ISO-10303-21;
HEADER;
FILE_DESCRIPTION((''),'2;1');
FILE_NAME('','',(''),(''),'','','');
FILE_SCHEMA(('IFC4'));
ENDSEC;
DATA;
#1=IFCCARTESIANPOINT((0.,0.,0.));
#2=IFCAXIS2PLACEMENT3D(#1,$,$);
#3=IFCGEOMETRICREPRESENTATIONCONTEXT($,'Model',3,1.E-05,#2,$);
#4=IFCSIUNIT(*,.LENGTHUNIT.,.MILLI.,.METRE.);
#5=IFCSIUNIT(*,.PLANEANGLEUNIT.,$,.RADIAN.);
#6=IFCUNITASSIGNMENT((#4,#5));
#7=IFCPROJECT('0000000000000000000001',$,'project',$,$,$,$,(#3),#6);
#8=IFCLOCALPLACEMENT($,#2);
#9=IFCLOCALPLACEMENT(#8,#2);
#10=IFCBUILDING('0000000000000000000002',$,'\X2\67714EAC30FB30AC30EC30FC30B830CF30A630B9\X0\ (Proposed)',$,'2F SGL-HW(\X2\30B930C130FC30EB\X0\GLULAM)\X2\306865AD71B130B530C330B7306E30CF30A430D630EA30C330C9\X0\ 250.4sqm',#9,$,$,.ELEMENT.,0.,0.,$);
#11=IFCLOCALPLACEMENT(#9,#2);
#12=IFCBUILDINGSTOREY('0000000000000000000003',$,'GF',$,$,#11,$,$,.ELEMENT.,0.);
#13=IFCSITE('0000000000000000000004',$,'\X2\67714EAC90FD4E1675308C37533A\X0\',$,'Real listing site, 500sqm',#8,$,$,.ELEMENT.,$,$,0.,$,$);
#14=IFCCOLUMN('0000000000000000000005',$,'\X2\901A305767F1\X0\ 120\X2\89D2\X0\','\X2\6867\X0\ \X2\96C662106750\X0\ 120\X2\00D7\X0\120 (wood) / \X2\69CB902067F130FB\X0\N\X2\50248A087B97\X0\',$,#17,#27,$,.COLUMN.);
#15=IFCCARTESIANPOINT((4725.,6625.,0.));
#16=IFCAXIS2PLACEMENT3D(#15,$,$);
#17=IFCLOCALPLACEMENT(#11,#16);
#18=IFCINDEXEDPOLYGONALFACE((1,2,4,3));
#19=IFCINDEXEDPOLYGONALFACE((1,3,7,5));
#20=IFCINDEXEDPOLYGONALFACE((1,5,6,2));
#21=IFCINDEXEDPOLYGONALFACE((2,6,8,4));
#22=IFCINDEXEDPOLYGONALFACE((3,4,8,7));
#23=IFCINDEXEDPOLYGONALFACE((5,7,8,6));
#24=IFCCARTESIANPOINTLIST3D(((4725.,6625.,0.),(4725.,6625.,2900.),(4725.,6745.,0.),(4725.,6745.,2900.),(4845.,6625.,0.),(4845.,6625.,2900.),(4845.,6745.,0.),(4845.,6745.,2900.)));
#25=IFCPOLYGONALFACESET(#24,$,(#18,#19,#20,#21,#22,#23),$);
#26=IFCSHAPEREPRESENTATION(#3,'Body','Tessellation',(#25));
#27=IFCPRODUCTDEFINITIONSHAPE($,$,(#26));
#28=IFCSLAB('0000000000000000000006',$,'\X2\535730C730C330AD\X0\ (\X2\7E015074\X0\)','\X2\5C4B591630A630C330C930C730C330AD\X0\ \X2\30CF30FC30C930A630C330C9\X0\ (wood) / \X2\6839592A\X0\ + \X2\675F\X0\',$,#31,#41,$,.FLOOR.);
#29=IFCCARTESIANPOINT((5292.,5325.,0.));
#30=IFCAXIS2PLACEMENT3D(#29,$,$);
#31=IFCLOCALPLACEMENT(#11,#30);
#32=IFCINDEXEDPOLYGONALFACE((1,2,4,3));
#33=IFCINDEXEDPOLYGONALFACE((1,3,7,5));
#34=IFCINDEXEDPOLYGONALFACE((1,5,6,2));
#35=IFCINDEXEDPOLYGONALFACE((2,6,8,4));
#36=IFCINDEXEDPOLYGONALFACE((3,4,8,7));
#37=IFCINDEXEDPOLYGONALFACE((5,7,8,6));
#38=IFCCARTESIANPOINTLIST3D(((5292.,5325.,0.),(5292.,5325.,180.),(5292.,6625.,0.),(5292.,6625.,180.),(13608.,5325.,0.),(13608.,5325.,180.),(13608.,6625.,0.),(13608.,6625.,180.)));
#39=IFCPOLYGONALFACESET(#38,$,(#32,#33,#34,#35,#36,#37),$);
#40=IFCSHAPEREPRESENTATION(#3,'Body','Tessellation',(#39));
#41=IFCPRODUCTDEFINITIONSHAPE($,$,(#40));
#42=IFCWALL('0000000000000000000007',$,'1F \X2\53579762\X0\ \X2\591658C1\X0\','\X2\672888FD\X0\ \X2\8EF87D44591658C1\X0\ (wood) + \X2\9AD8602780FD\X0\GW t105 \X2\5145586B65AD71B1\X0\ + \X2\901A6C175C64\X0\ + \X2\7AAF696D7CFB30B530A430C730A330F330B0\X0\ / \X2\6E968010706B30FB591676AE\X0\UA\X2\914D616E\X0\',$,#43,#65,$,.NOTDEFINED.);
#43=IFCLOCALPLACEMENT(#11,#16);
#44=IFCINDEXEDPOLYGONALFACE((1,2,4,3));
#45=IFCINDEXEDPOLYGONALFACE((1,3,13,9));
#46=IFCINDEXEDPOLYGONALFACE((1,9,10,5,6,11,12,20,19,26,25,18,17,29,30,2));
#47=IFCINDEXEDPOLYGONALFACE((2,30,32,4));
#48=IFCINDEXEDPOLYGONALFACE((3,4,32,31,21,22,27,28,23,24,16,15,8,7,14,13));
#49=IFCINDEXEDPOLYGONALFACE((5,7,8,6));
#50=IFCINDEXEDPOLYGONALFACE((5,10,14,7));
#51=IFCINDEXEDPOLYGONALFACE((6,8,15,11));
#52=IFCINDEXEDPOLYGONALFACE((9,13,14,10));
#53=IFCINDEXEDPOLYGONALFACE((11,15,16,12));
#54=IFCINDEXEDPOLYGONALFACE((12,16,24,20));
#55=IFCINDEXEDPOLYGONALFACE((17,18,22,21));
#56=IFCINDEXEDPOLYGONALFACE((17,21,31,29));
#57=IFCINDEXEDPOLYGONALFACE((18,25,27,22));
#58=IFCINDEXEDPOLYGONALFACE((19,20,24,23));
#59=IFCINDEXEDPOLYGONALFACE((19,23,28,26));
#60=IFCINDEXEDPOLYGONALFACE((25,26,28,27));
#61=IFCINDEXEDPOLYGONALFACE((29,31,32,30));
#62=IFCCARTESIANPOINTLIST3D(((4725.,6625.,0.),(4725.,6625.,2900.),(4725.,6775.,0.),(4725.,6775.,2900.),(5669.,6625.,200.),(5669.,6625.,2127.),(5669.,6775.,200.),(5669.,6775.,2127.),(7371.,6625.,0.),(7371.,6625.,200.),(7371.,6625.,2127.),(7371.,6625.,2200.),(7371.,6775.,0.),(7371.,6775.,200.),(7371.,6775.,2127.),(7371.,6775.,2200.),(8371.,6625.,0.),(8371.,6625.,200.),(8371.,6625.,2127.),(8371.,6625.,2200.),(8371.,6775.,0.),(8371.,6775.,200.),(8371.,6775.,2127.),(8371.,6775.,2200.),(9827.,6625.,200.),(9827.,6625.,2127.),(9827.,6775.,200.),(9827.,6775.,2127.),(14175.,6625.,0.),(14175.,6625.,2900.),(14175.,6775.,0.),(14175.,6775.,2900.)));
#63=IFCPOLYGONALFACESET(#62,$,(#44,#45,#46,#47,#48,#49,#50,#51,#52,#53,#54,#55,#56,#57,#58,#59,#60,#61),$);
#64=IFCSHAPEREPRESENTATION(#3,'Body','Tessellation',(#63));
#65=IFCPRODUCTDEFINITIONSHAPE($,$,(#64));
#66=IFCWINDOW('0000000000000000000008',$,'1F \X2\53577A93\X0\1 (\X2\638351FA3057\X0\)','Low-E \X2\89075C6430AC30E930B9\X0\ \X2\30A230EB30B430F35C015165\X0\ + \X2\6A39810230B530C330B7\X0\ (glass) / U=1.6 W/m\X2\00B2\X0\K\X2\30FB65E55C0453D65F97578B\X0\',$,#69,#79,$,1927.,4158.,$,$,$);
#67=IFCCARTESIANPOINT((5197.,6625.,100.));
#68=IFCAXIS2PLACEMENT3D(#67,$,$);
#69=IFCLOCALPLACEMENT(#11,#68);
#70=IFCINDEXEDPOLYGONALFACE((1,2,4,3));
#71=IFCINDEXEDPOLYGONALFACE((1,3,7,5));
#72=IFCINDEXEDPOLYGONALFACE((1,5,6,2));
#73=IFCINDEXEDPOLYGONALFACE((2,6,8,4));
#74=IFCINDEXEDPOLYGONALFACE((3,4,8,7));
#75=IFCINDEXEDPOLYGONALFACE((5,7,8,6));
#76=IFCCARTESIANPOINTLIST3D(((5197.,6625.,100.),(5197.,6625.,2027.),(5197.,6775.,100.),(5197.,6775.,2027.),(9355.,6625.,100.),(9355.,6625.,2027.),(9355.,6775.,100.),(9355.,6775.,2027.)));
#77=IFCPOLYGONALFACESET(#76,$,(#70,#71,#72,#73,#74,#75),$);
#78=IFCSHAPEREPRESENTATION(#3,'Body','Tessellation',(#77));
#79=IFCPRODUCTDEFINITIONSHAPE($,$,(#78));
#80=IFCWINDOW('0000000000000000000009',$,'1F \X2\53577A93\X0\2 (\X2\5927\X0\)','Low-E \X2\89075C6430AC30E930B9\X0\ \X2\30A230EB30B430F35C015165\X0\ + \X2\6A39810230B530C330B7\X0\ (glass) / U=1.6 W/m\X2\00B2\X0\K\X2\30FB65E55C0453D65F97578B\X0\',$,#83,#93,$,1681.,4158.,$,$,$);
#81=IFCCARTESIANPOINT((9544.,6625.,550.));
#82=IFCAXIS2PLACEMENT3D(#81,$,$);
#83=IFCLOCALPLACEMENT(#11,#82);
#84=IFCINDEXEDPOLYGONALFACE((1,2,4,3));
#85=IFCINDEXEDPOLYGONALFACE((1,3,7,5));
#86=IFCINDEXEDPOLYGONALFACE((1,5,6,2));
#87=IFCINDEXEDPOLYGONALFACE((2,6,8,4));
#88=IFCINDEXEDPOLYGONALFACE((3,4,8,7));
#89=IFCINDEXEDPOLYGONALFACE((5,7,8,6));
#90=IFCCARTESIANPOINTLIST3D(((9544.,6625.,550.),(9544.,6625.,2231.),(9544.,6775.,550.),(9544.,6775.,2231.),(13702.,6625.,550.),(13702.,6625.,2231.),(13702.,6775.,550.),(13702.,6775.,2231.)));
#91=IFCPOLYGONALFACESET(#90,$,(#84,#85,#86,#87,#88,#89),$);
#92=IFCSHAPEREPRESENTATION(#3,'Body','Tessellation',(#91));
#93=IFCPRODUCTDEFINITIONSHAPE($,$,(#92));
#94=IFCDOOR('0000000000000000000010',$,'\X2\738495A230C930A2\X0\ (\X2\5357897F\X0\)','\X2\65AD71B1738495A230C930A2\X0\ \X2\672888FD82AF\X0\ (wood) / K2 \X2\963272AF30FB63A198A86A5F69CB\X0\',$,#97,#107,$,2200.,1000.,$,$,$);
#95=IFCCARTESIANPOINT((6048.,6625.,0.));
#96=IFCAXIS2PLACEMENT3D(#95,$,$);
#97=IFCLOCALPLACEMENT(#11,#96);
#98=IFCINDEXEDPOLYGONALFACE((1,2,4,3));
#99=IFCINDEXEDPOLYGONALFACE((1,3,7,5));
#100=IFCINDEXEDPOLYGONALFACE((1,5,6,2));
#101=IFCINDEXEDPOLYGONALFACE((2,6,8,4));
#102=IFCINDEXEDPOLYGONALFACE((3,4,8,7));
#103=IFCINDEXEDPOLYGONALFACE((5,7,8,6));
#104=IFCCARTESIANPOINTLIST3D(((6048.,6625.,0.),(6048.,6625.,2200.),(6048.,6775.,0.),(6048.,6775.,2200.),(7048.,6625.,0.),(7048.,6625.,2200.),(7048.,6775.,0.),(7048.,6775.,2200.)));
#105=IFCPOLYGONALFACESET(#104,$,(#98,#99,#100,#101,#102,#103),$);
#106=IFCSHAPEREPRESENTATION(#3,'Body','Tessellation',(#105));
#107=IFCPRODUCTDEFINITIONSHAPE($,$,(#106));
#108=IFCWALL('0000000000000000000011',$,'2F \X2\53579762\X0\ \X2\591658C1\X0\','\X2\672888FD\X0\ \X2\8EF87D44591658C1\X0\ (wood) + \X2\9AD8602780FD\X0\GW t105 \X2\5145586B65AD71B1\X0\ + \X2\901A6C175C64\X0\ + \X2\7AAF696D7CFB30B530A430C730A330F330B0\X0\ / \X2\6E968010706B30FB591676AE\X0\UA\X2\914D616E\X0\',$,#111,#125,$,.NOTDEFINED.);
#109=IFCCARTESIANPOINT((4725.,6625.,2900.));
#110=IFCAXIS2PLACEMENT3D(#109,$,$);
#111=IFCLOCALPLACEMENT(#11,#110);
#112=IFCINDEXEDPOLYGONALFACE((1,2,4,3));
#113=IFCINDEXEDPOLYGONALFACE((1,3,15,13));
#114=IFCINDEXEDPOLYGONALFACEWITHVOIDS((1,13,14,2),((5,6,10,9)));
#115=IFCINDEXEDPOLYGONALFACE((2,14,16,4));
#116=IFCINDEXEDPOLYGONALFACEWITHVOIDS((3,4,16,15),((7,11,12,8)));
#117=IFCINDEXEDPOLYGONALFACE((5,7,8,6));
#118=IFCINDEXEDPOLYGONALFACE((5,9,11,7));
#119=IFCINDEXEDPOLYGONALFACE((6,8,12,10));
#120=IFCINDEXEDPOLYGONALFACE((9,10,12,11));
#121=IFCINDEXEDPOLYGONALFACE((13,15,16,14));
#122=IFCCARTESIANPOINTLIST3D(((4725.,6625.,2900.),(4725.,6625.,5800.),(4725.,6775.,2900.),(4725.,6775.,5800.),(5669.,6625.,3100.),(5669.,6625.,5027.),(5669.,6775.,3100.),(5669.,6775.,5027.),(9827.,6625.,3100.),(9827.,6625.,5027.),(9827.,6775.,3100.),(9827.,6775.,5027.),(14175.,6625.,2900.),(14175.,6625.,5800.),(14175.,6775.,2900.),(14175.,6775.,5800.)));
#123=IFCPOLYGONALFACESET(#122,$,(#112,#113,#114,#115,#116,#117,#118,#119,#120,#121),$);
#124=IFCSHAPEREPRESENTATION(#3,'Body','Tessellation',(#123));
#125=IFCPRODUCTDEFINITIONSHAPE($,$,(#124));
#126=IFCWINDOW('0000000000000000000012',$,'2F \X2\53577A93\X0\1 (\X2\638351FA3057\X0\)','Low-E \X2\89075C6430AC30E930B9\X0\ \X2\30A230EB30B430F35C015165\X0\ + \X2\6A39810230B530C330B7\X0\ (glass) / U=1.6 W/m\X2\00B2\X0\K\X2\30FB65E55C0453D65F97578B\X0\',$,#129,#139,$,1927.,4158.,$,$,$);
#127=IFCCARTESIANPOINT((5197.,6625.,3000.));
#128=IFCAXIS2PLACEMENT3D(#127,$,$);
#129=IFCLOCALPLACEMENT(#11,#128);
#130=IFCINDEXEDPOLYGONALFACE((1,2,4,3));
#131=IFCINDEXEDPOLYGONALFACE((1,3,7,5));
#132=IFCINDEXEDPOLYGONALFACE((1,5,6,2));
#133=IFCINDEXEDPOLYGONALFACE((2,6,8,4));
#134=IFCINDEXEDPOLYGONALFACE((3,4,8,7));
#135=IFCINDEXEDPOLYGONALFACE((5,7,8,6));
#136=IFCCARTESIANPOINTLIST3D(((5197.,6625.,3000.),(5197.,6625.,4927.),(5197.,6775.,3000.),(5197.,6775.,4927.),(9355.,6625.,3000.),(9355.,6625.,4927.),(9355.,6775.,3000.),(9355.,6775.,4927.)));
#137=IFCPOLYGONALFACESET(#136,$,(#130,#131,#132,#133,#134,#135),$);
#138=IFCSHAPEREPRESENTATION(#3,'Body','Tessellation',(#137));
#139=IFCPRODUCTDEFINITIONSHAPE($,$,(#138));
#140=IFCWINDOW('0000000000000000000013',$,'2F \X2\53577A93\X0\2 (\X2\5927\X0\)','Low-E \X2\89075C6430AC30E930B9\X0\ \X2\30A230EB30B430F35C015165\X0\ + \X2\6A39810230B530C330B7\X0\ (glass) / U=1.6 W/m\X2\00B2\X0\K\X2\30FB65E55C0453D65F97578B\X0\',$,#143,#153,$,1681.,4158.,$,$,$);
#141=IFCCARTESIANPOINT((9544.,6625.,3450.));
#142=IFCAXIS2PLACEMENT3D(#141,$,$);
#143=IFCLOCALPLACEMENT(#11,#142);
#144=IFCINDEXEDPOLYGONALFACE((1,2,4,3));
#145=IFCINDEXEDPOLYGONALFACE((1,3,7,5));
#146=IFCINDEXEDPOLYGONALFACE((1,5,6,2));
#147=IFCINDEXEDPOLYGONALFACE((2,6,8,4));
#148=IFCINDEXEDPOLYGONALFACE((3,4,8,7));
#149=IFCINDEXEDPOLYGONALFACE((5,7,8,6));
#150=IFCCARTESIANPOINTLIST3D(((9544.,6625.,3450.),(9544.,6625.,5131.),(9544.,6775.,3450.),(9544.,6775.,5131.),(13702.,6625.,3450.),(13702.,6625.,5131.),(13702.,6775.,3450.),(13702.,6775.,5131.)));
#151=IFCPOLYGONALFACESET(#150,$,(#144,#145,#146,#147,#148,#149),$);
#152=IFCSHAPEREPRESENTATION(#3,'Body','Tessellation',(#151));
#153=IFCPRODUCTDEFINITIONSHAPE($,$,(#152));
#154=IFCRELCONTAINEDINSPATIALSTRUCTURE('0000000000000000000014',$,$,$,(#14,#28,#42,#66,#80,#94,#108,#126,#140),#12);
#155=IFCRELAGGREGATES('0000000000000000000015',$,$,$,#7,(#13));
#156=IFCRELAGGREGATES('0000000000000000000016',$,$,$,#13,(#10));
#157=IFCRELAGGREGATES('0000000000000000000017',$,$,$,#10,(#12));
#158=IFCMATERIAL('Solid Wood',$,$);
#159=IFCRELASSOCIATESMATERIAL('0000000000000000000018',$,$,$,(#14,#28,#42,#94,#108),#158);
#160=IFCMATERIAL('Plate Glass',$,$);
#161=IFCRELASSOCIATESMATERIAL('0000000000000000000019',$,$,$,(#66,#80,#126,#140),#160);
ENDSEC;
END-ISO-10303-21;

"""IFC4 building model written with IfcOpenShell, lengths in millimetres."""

from ifc_helpers import new_model, si_unit, frame, frame_2d, origin, place, context, project, spatial, rectangle, extrude, material, element, fill, save


model = new_model("IFC4")

# Units and contexts
model_context = context("Model", 3, precision=1e-05, world=origin())
ifc_project = project(units=[si_unit("LENGTHUNIT", "METRE", prefix="MILLI"), si_unit("PLANEANGLEUNIT", "RADIAN")], contexts=[model_context])

# Site, building, storey
site_placement = place(None, origin())
site = spatial("IfcSite", under=ifc_project, at=site_placement, Name="東京都世田谷区", ObjectType="Real listing site, 500sqm", CompositionType="ELEMENT", RefElevation=0.0)
building_placement = place(site_placement, origin())
building = spatial("IfcBuilding", under=site, at=building_placement, Name="東京・ガレージハウス (Proposed)", ObjectType="2F SGL-HW(スチールGLULAM)と断熱サッシのハイブリッド 250.4sqm", CompositionType="ELEMENT", ElevationOfRefHeight=0.0, ElevationOfTerrain=0.0)
storey_placement = place(building_placement, origin())
storey = spatial("IfcBuildingStorey", under=building, at=storey_placement, Name="GF", CompositionType="ELEMENT", Elevation=0.0)

# Column
ifc_material_1 = material(Name="Solid Wood")
column_placement = place(storey_placement, frame((4725.0, 6625.0, 0.0)))
element("IfcColumn", 1, at=column_placement, inside=storey, material=ifc_material_1, Name="通し柱 120角", Description="桧 集成材 120×120 (wood) / 構造柱・N値計算", PredefinedType="COLUMN", context=model_context, shape_type="SweptSolid", body=[
    extrude(rectangle(XDim=120.0, YDim=120.0, at=frame_2d((60.0, 60.0))), frame((4725.0, 6625.0, 0.0)), (0.0, 0.0, 1.0), 2900.0),
])

# Slab
slab_1_placement = place(storey_placement, frame((5292.0, 5325.0, 0.0)))
element("IfcSlab", 2, at=slab_1_placement, inside=storey, material=ifc_material_1, Name="南デッキ (縁側)", Description="屋外ウッドデッキ ハードウッド (wood) / 根太 + 束", PredefinedType="FLOOR", context=model_context, shape_type="SweptSolid", body=[
    extrude(rectangle(XDim=8316.0, YDim=1300.0, at=frame_2d((4158.0, 650.0))), frame((5292.0, 5325.0, 0.0)), (0.0, 0.0, 1.0), 180.0),
])

# Wall, openings, windows, door
wall_1_placement = place(storey_placement, frame((4725.0, 6625.0, 0.0)))
wall_1 = element("IfcWall", 3, at=wall_1_placement, inside=storey, material=ifc_material_1, Name="1F 南面 外壁", Description="木製 軸組外壁 (wood) + 高性能GW t105 充填断熱 + 通気層 + 窯業系サイディング / 準耐火・外皮UA配慮", PredefinedType="NOTDEFINED", context=model_context, shape_type="SweptSolid", body=[
    extrude(rectangle(XDim=9450.0, YDim=150.0, at=frame_2d((4725.0, 75.0))), frame((4725.0, 6625.0, 0.0)), (0.0, 0.0, 1.0), 2900.0),
])
opening_1_placement = place(storey_placement, frame((5197.0, 6625.0, 100.0)))
opening_1 = element("IfcOpeningElement", 4, at=opening_1_placement, cuts=wall_1, PredefinedType="NOTDEFINED", context=model_context, shape_type="SweptSolid", body=[
    extrude(rectangle(XDim=4158.0, YDim=150.0, at=frame_2d((2079.0, 75.0))), frame((5197.0, 6625.0, 100.0)), (0.0, 0.0, 1.0), 1927.0),
])
opening_2_placement = place(storey_placement, frame((9544.0, 6625.0, 550.0)))
opening_2 = element("IfcOpeningElement", 5, at=opening_2_placement, cuts=wall_1, PredefinedType="NOTDEFINED", context=model_context, shape_type="SweptSolid", body=[
    extrude(rectangle(XDim=4158.0, YDim=150.0, at=frame_2d((2079.0, 75.0))), frame((9544.0, 6625.0, 550.0)), (0.0, 0.0, 1.0), 1681.0),
])
opening_3_placement = place(storey_placement, frame((6048.0, 6625.0, 0.0)))
opening_3 = element("IfcOpeningElement", 6, at=opening_3_placement, cuts=wall_1, PredefinedType="NOTDEFINED", context=model_context, shape_type="SweptSolid", body=[
    extrude(rectangle(XDim=1000.0, YDim=150.0, at=frame_2d((500.0, 75.0))), frame((6048.0, 6625.0, 0.0)), (0.0, 0.0, 1.0), 2200.0),
])
ifc_material_2 = material(Name="Plate Glass")
window_1_placement = place(storey_placement, frame((5197.0, 6625.0, 100.0)))
window_1 = element("IfcWindow", 7, at=window_1_placement, inside=storey, material=ifc_material_2, Name="1F 南窓1 (掃出し)", Description="Low-E 複層ガラス アルゴン封入 + 樹脂サッシ (glass) / U=1.6 W/m²K・日射取得型", OverallHeight=1927.0, OverallWidth=4158.0, context=model_context, shape_type="SweptSolid", body=[
    extrude(rectangle(XDim=4158.0, YDim=150.0, at=frame_2d((2079.0, 75.0))), frame((5197.0, 6625.0, 100.0)), (0.0, 0.0, 1.0), 1927.0),
])
fill(opening_1, window_1)
window_2_placement = place(storey_placement, frame((9544.0, 6625.0, 550.0)))
window_2 = element("IfcWindow", 8, at=window_2_placement, inside=storey, material=ifc_material_2, Name="1F 南窓2 (大)", Description="Low-E 複層ガラス アルゴン封入 + 樹脂サッシ (glass) / U=1.6 W/m²K・日射取得型", OverallHeight=1681.0, OverallWidth=4158.0, context=model_context, shape_type="SweptSolid", body=[
    extrude(rectangle(XDim=4158.0, YDim=150.0, at=frame_2d((2079.0, 75.0))), frame((9544.0, 6625.0, 550.0)), (0.0, 0.0, 1.0), 1681.0),
])
fill(opening_2, window_2)
door_placement = place(storey_placement, frame((6048.0, 6625.0, 0.0)))
door = element("IfcDoor", 9, at=door_placement, inside=storey, material=ifc_material_1, Name="玄関ドア (南西)", Description="断熱玄関ドア 木製芯 (wood) / K2 防犯・採風機構", OverallHeight=2200.0, OverallWidth=1000.0, context=model_context, shape_type="SweptSolid", body=[
    extrude(rectangle(XDim=1000.0, YDim=150.0, at=frame_2d((500.0, 75.0))), frame((6048.0, 6625.0, 0.0)), (0.0, 0.0, 1.0), 2200.0),
])
fill(opening_3, door)

# Wall, openings, windows
wall_2_placement = place(storey_placement, frame((4725.0, 6625.0, 2900.0)))
wall_2 = element("IfcWall", 10, at=wall_2_placement, inside=storey, material=ifc_material_1, Name="2F 南面 外壁", Description="木製 軸組外壁 (wood) + 高性能GW t105 充填断熱 + 通気層 + 窯業系サイディング / 準耐火・外皮UA配慮", PredefinedType="NOTDEFINED", context=model_context, shape_type="SweptSolid", body=[
    extrude(rectangle(XDim=9450.0, YDim=150.0, at=frame_2d((4725.0, 75.0))), frame((4725.0, 6625.0, 2900.0)), (0.0, 0.0, 1.0), 2900.0),
])
opening_4_placement = place(storey_placement, frame((5197.0, 6625.0, 3000.0)))
opening_4 = element("IfcOpeningElement", 11, at=opening_4_placement, cuts=wall_2, PredefinedType="NOTDEFINED", context=model_context, shape_type="SweptSolid", body=[
    extrude(rectangle(XDim=4158.0, YDim=150.0, at=frame_2d((2079.0, 75.0))), frame((5197.0, 6625.0, 3000.0)), (0.0, 0.0, 1.0), 1927.0),
])
opening_5_placement = place(storey_placement, frame((9544.0, 6625.0, 3450.0)))
opening_5 = element("IfcOpeningElement", 12, at=opening_5_placement, cuts=wall_2, PredefinedType="NOTDEFINED", context=model_context, shape_type="SweptSolid", body=[
    extrude(rectangle(XDim=4158.0, YDim=150.0, at=frame_2d((2079.0, 75.0))), frame((9544.0, 6625.0, 3450.0)), (0.0, 0.0, 1.0), 1681.0),
])
window_3_placement = place(storey_placement, frame((5197.0, 6625.0, 3000.0)))
window_3 = element("IfcWindow", 13, at=window_3_placement, inside=storey, material=ifc_material_2, Name="2F 南窓1 (掃出し)", Description="Low-E 複層ガラス アルゴン封入 + 樹脂サッシ (glass) / U=1.6 W/m²K・日射取得型", OverallHeight=1927.0, OverallWidth=4158.0, context=model_context, shape_type="SweptSolid", body=[
    extrude(rectangle(XDim=4158.0, YDim=150.0, at=frame_2d((2079.0, 75.0))), frame((5197.0, 6625.0, 3000.0)), (0.0, 0.0, 1.0), 1927.0),
])
fill(opening_4, window_3)
window_4_placement = place(storey_placement, frame((9544.0, 6625.0, 3450.0)))
window_4 = element("IfcWindow", 14, at=window_4_placement, inside=storey, material=ifc_material_2, Name="2F 南窓2 (大)", Description="Low-E 複層ガラス アルゴン封入 + 樹脂サッシ (glass) / U=1.6 W/m²K・日射取得型", OverallHeight=1681.0, OverallWidth=4158.0, context=model_context, shape_type="SweptSolid", body=[
    extrude(rectangle(XDim=4158.0, YDim=150.0, at=frame_2d((2079.0, 75.0))), frame((9544.0, 6625.0, 3450.0)), (0.0, 0.0, 1.0), 1681.0),
])
fill(opening_5, window_4)

save(model, "model.ifc")
